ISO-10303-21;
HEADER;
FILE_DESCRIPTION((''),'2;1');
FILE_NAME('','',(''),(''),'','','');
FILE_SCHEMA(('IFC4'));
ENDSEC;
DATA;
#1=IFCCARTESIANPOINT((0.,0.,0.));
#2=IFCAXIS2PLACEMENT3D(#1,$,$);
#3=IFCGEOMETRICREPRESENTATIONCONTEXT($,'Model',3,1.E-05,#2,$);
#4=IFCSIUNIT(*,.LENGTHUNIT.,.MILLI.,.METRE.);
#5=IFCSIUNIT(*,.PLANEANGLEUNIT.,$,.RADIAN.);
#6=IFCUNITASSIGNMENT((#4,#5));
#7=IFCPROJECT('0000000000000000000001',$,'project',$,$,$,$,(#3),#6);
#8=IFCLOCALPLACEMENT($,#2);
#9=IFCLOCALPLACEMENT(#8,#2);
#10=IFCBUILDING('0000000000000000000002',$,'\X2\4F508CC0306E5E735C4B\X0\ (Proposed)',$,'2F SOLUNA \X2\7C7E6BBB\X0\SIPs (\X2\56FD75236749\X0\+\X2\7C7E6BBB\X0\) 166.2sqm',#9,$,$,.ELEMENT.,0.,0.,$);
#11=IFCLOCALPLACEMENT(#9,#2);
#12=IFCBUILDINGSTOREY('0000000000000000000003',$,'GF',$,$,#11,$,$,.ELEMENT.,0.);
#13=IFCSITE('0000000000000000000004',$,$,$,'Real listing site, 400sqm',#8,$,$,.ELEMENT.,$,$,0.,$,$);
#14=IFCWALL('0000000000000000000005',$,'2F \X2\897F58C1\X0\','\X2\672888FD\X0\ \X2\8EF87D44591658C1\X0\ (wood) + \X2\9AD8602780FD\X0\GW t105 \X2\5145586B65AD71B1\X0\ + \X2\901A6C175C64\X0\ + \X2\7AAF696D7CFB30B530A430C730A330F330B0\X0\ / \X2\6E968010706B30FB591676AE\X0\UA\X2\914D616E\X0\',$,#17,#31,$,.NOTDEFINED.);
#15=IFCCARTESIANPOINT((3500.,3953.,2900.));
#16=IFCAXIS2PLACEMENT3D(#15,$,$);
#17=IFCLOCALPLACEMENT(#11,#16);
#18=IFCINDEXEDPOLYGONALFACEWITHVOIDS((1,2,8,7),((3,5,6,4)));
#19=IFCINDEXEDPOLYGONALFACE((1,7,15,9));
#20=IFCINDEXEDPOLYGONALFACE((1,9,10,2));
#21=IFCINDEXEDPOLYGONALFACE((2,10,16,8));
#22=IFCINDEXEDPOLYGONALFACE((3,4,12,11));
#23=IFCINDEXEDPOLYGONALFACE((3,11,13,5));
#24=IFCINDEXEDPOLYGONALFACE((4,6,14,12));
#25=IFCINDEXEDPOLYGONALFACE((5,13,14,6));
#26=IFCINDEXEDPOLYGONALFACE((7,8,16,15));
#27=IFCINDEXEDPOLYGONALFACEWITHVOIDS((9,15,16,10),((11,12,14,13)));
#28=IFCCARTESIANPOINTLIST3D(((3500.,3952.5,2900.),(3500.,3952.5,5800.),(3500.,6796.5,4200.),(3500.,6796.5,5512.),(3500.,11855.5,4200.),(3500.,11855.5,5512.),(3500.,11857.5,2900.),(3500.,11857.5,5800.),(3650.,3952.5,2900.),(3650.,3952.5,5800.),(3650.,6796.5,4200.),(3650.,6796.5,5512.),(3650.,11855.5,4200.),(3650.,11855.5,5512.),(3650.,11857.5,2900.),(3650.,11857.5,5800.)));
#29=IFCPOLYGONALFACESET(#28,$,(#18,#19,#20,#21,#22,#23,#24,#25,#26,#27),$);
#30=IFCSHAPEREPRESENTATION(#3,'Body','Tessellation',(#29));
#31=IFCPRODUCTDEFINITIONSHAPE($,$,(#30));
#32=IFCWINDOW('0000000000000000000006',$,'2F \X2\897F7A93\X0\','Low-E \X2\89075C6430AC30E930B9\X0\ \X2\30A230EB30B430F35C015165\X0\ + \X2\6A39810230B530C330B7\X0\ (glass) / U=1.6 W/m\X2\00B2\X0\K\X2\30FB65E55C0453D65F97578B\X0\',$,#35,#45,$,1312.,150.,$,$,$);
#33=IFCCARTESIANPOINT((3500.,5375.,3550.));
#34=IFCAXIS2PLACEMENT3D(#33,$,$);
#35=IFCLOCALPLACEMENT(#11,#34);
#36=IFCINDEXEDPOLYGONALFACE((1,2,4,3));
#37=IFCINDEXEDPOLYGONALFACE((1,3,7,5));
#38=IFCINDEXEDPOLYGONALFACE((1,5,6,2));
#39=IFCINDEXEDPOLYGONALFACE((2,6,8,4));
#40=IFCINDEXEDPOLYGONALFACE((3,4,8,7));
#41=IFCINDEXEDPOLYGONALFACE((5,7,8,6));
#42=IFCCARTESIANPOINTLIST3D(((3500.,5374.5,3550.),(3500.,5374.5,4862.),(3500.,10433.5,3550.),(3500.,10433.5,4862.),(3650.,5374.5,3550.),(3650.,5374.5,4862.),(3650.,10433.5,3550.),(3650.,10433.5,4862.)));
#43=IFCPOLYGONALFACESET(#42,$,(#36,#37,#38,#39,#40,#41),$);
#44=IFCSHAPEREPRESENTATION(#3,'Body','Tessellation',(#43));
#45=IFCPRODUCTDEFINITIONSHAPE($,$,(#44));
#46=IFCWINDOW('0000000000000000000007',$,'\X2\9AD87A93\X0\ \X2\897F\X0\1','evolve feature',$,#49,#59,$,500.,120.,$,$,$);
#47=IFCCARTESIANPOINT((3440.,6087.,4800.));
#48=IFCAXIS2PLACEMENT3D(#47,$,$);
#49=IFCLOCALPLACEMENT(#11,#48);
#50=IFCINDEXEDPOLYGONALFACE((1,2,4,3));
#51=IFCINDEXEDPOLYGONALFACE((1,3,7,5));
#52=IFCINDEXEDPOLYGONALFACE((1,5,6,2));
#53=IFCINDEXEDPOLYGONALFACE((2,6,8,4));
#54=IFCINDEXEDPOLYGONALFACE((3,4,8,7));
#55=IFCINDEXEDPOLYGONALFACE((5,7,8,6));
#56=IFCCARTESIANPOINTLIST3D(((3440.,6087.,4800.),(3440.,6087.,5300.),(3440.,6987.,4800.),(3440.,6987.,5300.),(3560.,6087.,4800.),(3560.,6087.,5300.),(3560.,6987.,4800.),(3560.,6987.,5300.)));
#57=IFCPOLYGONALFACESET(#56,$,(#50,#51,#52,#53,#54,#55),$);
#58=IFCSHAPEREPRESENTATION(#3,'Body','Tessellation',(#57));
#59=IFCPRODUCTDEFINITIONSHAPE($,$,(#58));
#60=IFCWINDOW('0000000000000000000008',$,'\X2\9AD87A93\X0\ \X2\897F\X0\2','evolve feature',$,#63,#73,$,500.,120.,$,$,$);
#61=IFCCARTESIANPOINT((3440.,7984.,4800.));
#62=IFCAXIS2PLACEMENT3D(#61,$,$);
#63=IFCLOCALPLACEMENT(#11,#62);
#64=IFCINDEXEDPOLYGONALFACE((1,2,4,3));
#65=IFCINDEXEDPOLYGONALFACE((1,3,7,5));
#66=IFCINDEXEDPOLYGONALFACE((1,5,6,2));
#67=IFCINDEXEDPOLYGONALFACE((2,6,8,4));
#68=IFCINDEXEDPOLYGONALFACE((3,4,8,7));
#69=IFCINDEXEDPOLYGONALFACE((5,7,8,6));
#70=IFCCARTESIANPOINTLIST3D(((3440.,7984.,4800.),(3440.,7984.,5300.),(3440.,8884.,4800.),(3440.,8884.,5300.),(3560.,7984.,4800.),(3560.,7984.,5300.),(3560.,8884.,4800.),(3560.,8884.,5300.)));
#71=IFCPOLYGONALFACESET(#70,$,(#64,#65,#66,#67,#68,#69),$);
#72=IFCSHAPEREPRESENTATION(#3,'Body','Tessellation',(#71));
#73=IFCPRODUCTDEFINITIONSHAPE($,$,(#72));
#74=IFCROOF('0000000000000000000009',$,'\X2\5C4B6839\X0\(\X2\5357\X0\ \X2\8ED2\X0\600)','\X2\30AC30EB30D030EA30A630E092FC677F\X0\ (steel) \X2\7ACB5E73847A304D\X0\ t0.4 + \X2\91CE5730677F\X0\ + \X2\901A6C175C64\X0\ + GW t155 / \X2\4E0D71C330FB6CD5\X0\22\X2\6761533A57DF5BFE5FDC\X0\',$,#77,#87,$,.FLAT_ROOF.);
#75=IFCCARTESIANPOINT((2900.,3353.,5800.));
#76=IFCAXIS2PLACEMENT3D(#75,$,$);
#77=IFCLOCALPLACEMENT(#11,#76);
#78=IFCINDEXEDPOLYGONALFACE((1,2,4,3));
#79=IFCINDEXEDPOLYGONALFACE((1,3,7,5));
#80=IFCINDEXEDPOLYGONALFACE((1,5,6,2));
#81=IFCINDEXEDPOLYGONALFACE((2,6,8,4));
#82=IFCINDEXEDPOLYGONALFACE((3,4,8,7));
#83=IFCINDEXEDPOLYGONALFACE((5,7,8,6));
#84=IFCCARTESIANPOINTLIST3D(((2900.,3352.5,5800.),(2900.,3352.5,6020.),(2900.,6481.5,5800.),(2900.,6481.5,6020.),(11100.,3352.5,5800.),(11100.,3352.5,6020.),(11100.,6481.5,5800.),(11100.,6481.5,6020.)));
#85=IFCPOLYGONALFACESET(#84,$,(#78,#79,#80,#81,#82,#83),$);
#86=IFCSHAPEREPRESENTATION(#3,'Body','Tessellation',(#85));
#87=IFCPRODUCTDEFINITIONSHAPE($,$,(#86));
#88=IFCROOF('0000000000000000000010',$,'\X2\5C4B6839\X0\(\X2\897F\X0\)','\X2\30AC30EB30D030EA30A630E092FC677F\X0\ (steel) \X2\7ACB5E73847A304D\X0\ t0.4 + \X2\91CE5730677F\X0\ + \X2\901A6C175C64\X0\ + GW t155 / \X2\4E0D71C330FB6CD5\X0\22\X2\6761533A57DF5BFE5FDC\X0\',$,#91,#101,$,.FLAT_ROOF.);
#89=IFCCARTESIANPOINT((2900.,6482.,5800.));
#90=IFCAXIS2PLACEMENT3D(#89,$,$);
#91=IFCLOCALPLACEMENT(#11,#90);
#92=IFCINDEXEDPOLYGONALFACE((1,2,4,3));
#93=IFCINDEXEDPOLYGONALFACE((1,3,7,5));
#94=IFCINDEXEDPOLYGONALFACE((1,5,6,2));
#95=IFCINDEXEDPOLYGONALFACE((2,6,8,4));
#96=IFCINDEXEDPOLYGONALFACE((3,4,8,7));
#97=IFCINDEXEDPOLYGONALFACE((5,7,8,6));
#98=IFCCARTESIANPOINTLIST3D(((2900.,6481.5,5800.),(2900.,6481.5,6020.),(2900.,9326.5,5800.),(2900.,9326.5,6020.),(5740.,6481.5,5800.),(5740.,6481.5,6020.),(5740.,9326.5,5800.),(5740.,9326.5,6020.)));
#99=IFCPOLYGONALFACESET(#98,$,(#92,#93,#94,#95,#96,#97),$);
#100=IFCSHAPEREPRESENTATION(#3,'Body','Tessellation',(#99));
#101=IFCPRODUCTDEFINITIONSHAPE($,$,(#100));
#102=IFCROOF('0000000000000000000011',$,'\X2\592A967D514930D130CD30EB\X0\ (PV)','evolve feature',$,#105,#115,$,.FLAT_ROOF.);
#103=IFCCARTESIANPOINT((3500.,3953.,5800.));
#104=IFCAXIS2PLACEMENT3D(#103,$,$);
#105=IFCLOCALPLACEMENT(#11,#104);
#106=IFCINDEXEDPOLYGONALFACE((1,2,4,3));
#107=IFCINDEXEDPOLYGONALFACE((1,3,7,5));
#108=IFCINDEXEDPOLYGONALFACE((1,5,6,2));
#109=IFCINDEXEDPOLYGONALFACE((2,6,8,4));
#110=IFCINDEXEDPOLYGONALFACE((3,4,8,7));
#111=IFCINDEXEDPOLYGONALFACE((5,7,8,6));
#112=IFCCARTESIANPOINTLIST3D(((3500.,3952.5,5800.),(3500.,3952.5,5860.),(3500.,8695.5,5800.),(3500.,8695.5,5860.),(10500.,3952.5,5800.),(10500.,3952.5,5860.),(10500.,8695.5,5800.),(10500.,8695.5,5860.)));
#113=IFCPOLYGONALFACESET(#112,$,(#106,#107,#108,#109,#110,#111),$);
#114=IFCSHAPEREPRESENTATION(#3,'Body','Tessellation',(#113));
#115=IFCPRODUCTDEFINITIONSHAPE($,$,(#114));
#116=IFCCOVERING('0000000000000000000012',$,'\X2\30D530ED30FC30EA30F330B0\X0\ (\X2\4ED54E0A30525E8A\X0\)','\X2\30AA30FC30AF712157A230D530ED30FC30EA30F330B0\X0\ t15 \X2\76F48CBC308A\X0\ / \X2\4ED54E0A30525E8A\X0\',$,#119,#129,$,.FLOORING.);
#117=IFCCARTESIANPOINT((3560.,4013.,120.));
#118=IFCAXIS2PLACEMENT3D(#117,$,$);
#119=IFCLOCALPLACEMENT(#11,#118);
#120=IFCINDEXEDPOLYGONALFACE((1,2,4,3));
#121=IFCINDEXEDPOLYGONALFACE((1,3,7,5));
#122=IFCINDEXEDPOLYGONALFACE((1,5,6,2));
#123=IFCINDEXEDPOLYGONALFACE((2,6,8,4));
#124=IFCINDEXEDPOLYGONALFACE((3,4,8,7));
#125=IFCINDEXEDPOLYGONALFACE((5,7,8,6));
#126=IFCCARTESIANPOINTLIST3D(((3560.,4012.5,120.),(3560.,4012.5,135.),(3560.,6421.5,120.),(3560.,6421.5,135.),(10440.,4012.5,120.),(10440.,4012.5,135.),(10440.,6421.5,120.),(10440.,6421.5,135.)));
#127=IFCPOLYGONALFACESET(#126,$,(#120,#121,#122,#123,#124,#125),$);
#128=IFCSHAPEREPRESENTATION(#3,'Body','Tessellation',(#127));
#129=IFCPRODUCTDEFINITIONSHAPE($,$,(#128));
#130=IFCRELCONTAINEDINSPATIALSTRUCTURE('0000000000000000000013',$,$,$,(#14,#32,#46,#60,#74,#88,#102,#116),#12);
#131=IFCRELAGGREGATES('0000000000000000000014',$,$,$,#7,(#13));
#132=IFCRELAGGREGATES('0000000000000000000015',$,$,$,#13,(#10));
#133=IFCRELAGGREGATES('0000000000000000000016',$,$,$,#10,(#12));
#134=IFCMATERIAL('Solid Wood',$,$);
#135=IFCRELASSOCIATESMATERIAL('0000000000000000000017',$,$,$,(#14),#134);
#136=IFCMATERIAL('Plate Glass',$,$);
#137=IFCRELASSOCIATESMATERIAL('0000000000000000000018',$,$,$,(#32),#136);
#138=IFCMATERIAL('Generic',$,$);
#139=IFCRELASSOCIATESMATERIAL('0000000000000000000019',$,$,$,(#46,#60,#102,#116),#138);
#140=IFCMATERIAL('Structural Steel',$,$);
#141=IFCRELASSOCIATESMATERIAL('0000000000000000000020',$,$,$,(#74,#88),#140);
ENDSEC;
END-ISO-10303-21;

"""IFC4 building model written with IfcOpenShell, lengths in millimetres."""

from ifc_helpers import new_model, si_unit, frame, frame_2d, origin, place, context, project, spatial, rectangle, extrude, material, element, fill, save


model = new_model("IFC4")

# Units and contexts
model_context = context("Model", 3, precision=1e-05, world=origin())
ifc_project = project(units=[si_unit("LENGTHUNIT", "METRE", prefix="MILLI"), si_unit("PLANEANGLEUNIT", "RADIAN")], contexts=[model_context])

# Site, building, storey
site_placement = place(None, origin())
site = spatial("IfcSite", under=ifc_project, at=site_placement, ObjectType="Real listing site, 400sqm", CompositionType="ELEMENT", RefElevation=0.0)
building_placement = place(site_placement, origin())
building = spatial("IfcBuilding", under=site, at=building_placement, Name="佐賀の平屋 (Proposed)", ObjectType="2F SOLUNA 籾殻SIPs (国産杉+籾殻) 166.2sqm", CompositionType="ELEMENT", ElevationOfRefHeight=0.0, ElevationOfTerrain=0.0)
storey_placement = place(building_placement, origin())
storey = spatial("IfcBuildingStorey", under=building, at=storey_placement, Name="GF", CompositionType="ELEMENT", Elevation=0.0)

# Shared definitions
ifc_material_1 = material(Name="Solid Wood")
ifc_material_2 = material(Name="Generic")

# Shared definitions
ifc_material_3 = material(Name="Plate Glass")

# Wall, openings, windows
wall_1_placement = place(storey_placement, frame((3500.0, 3953.0, 2900.0)))
wall_1 = element("IfcWall", 1, at=wall_1_placement, inside=storey, material=ifc_material_1, Name="2F 西壁", Description="木製 軸組外壁 (wood) + 高性能GW t105 充填断熱 + 通気層 + 窯業系サイディング / 準耐火・外皮UA配慮", PredefinedType="NOTDEFINED", context=model_context, shape_type="SweptSolid", body=[
    extrude(rectangle(XDim=150.0, YDim=7905.0, at=frame_2d((75.0, 3952.0))), frame((3500.0, 3953.0, 2900.0)), (0.0, 0.0, 1.0), 2900.0),
])
opening_1_placement = place(storey_placement, frame((3500.0, 5375.0, 3550.0)))
opening_1 = element("IfcOpeningElement", 2, at=opening_1_placement, cuts=wall_1, PredefinedType="NOTDEFINED", context=model_context, shape_type="SweptSolid", body=[
    extrude(rectangle(XDim=150.0, YDim=5059.0, at=frame_2d((75.0, 2529.0))), frame((3500.0, 5375.0, 3550.0)), (0.0, 0.0, 1.0), 1312.0),
])
opening_2_placement = place(storey_placement, frame((3440.0, 6087.0, 4800.0)))
opening_2 = element("IfcOpeningElement", 3, at=opening_2_placement, cuts=wall_1, PredefinedType="NOTDEFINED", context=model_context, shape_type="SweptSolid", body=[
    extrude(rectangle(XDim=120.0, YDim=900.0, at=frame_2d((60.0, 450.0))), frame((3440.0, 6087.0, 4800.0)), (0.0, 0.0, 1.0), 500.0),
])
opening_3_placement = place(storey_placement, frame((3440.0, 7984.0, 4800.0)))
opening_3 = element("IfcOpeningElement", 4, at=opening_3_placement, cuts=wall_1, PredefinedType="NOTDEFINED", context=model_context, shape_type="SweptSolid", body=[
    extrude(rectangle(XDim=120.0, YDim=900.0, at=frame_2d((60.0, 450.0))), frame((3440.0, 7984.0, 4800.0)), (0.0, 0.0, 1.0), 500.0),
])
window_1_placement = place(storey_placement, frame((3500.0, 5375.0, 3550.0)))
window_1 = element("IfcWindow", 5, at=window_1_placement, inside=storey, material=ifc_material_3, Name="2F 西窓", Description="Low-E 複層ガラス アルゴン封入 + 樹脂サッシ (glass) / U=1.6 W/m²K・日射取得型", OverallHeight=1312.0, OverallWidth=150.0, context=model_context, shape_type="SweptSolid", body=[
    extrude(rectangle(XDim=150.0, YDim=5059.0, at=frame_2d((75.0, 2529.0))), frame((3500.0, 5375.0, 3550.0)), (0.0, 0.0, 1.0), 1312.0),
])
fill(opening_1, window_1)
window_2_placement = place(storey_placement, frame((3440.0, 6087.0, 4800.0)))
window_2 = element("IfcWindow", 6, at=window_2_placement, inside=storey, material=ifc_material_2, Name="高窓 西1", Description="evolve feature", OverallHeight=500.0, OverallWidth=120.0, context=model_context, shape_type="SweptSolid", body=[
    extrude(rectangle(XDim=120.0, YDim=900.0, at=frame_2d((60.0, 450.0))), frame((3440.0, 6087.0, 4800.0)), (0.0, 0.0, 1.0), 500.0),
])
fill(opening_2, window_2)
window_3_placement = place(storey_placement, frame((3440.0, 7984.0, 4800.0)))
window_3 = element("IfcWindow", 7, at=window_3_placement, inside=storey, material=ifc_material_2, Name="高窓 西2", Description="evolve feature", OverallHeight=500.0, OverallWidth=120.0, context=model_context, shape_type="SweptSolid", body=[
    extrude(rectangle(XDim=120.0, YDim=900.0, at=frame_2d((60.0, 450.0))), frame((3440.0, 7984.0, 4800.0)), (0.0, 0.0, 1.0), 500.0),
])
fill(opening_3, window_3)

# Roofs
ifc_material_4 = material(Name="Structural Steel")
roof_1_placement = place(storey_placement, frame((2900.0, 3353.0, 5800.0)))
element("IfcRoof", 8, at=roof_1_placement, inside=storey, material=ifc_material_4, Name="屋根(南 軒600)", Description="ガルバリウム鋼板 (steel) 立平葺き t0.4 + 野地板 + 通気層 + GW t155 / 不燃・法22条区域対応", PredefinedType="FLAT_ROOF", context=model_context, shape_type="SweptSolid", body=[
    extrude(rectangle(XDim=8200.0, YDim=3129.0, at=frame_2d((4100.0, 1564.0))), frame((2900.0, 3353.0, 5800.0)), (0.0, 0.0, 1.0), 220.0),
])
roof_2_placement = place(storey_placement, frame((2900.0, 6482.0, 5800.0)))
element("IfcRoof", 9, at=roof_2_placement, inside=storey, material=ifc_material_4, Name="屋根(西)", Description="ガルバリウム鋼板 (steel) 立平葺き t0.4 + 野地板 + 通気層 + GW t155 / 不燃・法22条区域対応", PredefinedType="FLAT_ROOF", context=model_context, shape_type="SweptSolid", body=[
    extrude(rectangle(XDim=2840.0, YDim=2845.0, at=frame_2d((1420.0, 1422.0))), frame((2900.0, 6482.0, 5800.0)), (0.0, 0.0, 1.0), 220.0),
])
roof_3_placement = place(storey_placement, frame((3500.0, 3953.0, 5800.0)))
element("IfcRoof", 10, at=roof_3_placement, inside=storey, material=ifc_material_2, Name="太陽光パネル (PV)", Description="evolve feature", PredefinedType="FLAT_ROOF", context=model_context, shape_type="SweptSolid", body=[
    extrude(rectangle(XDim=7000.0, YDim=4743.0, at=frame_2d((3500.0, 2371.0))), frame((3500.0, 3953.0, 5800.0)), (0.0, 0.0, 1.0), 60.0),
])

# Covering
covering_placement = place(storey_placement, frame((3560.0, 4013.0, 120.0)))
element("IfcCovering", 11, at=covering_placement, inside=storey, material=ifc_material_2, Name="フローリング (仕上げ床)", Description="オーク無垢フローリング t15 直貼り / 仕上げ床", PredefinedType="FLOORING", context=model_context, shape_type="SweptSolid", body=[
    extrude(rectangle(XDim=6880.0, YDim=2409.0, at=frame_2d((3440.0, 1204.0))), frame((3560.0, 4013.0, 120.0)), (0.0, 0.0, 1.0), 15.0),
])

save(model, "model.ifc")
